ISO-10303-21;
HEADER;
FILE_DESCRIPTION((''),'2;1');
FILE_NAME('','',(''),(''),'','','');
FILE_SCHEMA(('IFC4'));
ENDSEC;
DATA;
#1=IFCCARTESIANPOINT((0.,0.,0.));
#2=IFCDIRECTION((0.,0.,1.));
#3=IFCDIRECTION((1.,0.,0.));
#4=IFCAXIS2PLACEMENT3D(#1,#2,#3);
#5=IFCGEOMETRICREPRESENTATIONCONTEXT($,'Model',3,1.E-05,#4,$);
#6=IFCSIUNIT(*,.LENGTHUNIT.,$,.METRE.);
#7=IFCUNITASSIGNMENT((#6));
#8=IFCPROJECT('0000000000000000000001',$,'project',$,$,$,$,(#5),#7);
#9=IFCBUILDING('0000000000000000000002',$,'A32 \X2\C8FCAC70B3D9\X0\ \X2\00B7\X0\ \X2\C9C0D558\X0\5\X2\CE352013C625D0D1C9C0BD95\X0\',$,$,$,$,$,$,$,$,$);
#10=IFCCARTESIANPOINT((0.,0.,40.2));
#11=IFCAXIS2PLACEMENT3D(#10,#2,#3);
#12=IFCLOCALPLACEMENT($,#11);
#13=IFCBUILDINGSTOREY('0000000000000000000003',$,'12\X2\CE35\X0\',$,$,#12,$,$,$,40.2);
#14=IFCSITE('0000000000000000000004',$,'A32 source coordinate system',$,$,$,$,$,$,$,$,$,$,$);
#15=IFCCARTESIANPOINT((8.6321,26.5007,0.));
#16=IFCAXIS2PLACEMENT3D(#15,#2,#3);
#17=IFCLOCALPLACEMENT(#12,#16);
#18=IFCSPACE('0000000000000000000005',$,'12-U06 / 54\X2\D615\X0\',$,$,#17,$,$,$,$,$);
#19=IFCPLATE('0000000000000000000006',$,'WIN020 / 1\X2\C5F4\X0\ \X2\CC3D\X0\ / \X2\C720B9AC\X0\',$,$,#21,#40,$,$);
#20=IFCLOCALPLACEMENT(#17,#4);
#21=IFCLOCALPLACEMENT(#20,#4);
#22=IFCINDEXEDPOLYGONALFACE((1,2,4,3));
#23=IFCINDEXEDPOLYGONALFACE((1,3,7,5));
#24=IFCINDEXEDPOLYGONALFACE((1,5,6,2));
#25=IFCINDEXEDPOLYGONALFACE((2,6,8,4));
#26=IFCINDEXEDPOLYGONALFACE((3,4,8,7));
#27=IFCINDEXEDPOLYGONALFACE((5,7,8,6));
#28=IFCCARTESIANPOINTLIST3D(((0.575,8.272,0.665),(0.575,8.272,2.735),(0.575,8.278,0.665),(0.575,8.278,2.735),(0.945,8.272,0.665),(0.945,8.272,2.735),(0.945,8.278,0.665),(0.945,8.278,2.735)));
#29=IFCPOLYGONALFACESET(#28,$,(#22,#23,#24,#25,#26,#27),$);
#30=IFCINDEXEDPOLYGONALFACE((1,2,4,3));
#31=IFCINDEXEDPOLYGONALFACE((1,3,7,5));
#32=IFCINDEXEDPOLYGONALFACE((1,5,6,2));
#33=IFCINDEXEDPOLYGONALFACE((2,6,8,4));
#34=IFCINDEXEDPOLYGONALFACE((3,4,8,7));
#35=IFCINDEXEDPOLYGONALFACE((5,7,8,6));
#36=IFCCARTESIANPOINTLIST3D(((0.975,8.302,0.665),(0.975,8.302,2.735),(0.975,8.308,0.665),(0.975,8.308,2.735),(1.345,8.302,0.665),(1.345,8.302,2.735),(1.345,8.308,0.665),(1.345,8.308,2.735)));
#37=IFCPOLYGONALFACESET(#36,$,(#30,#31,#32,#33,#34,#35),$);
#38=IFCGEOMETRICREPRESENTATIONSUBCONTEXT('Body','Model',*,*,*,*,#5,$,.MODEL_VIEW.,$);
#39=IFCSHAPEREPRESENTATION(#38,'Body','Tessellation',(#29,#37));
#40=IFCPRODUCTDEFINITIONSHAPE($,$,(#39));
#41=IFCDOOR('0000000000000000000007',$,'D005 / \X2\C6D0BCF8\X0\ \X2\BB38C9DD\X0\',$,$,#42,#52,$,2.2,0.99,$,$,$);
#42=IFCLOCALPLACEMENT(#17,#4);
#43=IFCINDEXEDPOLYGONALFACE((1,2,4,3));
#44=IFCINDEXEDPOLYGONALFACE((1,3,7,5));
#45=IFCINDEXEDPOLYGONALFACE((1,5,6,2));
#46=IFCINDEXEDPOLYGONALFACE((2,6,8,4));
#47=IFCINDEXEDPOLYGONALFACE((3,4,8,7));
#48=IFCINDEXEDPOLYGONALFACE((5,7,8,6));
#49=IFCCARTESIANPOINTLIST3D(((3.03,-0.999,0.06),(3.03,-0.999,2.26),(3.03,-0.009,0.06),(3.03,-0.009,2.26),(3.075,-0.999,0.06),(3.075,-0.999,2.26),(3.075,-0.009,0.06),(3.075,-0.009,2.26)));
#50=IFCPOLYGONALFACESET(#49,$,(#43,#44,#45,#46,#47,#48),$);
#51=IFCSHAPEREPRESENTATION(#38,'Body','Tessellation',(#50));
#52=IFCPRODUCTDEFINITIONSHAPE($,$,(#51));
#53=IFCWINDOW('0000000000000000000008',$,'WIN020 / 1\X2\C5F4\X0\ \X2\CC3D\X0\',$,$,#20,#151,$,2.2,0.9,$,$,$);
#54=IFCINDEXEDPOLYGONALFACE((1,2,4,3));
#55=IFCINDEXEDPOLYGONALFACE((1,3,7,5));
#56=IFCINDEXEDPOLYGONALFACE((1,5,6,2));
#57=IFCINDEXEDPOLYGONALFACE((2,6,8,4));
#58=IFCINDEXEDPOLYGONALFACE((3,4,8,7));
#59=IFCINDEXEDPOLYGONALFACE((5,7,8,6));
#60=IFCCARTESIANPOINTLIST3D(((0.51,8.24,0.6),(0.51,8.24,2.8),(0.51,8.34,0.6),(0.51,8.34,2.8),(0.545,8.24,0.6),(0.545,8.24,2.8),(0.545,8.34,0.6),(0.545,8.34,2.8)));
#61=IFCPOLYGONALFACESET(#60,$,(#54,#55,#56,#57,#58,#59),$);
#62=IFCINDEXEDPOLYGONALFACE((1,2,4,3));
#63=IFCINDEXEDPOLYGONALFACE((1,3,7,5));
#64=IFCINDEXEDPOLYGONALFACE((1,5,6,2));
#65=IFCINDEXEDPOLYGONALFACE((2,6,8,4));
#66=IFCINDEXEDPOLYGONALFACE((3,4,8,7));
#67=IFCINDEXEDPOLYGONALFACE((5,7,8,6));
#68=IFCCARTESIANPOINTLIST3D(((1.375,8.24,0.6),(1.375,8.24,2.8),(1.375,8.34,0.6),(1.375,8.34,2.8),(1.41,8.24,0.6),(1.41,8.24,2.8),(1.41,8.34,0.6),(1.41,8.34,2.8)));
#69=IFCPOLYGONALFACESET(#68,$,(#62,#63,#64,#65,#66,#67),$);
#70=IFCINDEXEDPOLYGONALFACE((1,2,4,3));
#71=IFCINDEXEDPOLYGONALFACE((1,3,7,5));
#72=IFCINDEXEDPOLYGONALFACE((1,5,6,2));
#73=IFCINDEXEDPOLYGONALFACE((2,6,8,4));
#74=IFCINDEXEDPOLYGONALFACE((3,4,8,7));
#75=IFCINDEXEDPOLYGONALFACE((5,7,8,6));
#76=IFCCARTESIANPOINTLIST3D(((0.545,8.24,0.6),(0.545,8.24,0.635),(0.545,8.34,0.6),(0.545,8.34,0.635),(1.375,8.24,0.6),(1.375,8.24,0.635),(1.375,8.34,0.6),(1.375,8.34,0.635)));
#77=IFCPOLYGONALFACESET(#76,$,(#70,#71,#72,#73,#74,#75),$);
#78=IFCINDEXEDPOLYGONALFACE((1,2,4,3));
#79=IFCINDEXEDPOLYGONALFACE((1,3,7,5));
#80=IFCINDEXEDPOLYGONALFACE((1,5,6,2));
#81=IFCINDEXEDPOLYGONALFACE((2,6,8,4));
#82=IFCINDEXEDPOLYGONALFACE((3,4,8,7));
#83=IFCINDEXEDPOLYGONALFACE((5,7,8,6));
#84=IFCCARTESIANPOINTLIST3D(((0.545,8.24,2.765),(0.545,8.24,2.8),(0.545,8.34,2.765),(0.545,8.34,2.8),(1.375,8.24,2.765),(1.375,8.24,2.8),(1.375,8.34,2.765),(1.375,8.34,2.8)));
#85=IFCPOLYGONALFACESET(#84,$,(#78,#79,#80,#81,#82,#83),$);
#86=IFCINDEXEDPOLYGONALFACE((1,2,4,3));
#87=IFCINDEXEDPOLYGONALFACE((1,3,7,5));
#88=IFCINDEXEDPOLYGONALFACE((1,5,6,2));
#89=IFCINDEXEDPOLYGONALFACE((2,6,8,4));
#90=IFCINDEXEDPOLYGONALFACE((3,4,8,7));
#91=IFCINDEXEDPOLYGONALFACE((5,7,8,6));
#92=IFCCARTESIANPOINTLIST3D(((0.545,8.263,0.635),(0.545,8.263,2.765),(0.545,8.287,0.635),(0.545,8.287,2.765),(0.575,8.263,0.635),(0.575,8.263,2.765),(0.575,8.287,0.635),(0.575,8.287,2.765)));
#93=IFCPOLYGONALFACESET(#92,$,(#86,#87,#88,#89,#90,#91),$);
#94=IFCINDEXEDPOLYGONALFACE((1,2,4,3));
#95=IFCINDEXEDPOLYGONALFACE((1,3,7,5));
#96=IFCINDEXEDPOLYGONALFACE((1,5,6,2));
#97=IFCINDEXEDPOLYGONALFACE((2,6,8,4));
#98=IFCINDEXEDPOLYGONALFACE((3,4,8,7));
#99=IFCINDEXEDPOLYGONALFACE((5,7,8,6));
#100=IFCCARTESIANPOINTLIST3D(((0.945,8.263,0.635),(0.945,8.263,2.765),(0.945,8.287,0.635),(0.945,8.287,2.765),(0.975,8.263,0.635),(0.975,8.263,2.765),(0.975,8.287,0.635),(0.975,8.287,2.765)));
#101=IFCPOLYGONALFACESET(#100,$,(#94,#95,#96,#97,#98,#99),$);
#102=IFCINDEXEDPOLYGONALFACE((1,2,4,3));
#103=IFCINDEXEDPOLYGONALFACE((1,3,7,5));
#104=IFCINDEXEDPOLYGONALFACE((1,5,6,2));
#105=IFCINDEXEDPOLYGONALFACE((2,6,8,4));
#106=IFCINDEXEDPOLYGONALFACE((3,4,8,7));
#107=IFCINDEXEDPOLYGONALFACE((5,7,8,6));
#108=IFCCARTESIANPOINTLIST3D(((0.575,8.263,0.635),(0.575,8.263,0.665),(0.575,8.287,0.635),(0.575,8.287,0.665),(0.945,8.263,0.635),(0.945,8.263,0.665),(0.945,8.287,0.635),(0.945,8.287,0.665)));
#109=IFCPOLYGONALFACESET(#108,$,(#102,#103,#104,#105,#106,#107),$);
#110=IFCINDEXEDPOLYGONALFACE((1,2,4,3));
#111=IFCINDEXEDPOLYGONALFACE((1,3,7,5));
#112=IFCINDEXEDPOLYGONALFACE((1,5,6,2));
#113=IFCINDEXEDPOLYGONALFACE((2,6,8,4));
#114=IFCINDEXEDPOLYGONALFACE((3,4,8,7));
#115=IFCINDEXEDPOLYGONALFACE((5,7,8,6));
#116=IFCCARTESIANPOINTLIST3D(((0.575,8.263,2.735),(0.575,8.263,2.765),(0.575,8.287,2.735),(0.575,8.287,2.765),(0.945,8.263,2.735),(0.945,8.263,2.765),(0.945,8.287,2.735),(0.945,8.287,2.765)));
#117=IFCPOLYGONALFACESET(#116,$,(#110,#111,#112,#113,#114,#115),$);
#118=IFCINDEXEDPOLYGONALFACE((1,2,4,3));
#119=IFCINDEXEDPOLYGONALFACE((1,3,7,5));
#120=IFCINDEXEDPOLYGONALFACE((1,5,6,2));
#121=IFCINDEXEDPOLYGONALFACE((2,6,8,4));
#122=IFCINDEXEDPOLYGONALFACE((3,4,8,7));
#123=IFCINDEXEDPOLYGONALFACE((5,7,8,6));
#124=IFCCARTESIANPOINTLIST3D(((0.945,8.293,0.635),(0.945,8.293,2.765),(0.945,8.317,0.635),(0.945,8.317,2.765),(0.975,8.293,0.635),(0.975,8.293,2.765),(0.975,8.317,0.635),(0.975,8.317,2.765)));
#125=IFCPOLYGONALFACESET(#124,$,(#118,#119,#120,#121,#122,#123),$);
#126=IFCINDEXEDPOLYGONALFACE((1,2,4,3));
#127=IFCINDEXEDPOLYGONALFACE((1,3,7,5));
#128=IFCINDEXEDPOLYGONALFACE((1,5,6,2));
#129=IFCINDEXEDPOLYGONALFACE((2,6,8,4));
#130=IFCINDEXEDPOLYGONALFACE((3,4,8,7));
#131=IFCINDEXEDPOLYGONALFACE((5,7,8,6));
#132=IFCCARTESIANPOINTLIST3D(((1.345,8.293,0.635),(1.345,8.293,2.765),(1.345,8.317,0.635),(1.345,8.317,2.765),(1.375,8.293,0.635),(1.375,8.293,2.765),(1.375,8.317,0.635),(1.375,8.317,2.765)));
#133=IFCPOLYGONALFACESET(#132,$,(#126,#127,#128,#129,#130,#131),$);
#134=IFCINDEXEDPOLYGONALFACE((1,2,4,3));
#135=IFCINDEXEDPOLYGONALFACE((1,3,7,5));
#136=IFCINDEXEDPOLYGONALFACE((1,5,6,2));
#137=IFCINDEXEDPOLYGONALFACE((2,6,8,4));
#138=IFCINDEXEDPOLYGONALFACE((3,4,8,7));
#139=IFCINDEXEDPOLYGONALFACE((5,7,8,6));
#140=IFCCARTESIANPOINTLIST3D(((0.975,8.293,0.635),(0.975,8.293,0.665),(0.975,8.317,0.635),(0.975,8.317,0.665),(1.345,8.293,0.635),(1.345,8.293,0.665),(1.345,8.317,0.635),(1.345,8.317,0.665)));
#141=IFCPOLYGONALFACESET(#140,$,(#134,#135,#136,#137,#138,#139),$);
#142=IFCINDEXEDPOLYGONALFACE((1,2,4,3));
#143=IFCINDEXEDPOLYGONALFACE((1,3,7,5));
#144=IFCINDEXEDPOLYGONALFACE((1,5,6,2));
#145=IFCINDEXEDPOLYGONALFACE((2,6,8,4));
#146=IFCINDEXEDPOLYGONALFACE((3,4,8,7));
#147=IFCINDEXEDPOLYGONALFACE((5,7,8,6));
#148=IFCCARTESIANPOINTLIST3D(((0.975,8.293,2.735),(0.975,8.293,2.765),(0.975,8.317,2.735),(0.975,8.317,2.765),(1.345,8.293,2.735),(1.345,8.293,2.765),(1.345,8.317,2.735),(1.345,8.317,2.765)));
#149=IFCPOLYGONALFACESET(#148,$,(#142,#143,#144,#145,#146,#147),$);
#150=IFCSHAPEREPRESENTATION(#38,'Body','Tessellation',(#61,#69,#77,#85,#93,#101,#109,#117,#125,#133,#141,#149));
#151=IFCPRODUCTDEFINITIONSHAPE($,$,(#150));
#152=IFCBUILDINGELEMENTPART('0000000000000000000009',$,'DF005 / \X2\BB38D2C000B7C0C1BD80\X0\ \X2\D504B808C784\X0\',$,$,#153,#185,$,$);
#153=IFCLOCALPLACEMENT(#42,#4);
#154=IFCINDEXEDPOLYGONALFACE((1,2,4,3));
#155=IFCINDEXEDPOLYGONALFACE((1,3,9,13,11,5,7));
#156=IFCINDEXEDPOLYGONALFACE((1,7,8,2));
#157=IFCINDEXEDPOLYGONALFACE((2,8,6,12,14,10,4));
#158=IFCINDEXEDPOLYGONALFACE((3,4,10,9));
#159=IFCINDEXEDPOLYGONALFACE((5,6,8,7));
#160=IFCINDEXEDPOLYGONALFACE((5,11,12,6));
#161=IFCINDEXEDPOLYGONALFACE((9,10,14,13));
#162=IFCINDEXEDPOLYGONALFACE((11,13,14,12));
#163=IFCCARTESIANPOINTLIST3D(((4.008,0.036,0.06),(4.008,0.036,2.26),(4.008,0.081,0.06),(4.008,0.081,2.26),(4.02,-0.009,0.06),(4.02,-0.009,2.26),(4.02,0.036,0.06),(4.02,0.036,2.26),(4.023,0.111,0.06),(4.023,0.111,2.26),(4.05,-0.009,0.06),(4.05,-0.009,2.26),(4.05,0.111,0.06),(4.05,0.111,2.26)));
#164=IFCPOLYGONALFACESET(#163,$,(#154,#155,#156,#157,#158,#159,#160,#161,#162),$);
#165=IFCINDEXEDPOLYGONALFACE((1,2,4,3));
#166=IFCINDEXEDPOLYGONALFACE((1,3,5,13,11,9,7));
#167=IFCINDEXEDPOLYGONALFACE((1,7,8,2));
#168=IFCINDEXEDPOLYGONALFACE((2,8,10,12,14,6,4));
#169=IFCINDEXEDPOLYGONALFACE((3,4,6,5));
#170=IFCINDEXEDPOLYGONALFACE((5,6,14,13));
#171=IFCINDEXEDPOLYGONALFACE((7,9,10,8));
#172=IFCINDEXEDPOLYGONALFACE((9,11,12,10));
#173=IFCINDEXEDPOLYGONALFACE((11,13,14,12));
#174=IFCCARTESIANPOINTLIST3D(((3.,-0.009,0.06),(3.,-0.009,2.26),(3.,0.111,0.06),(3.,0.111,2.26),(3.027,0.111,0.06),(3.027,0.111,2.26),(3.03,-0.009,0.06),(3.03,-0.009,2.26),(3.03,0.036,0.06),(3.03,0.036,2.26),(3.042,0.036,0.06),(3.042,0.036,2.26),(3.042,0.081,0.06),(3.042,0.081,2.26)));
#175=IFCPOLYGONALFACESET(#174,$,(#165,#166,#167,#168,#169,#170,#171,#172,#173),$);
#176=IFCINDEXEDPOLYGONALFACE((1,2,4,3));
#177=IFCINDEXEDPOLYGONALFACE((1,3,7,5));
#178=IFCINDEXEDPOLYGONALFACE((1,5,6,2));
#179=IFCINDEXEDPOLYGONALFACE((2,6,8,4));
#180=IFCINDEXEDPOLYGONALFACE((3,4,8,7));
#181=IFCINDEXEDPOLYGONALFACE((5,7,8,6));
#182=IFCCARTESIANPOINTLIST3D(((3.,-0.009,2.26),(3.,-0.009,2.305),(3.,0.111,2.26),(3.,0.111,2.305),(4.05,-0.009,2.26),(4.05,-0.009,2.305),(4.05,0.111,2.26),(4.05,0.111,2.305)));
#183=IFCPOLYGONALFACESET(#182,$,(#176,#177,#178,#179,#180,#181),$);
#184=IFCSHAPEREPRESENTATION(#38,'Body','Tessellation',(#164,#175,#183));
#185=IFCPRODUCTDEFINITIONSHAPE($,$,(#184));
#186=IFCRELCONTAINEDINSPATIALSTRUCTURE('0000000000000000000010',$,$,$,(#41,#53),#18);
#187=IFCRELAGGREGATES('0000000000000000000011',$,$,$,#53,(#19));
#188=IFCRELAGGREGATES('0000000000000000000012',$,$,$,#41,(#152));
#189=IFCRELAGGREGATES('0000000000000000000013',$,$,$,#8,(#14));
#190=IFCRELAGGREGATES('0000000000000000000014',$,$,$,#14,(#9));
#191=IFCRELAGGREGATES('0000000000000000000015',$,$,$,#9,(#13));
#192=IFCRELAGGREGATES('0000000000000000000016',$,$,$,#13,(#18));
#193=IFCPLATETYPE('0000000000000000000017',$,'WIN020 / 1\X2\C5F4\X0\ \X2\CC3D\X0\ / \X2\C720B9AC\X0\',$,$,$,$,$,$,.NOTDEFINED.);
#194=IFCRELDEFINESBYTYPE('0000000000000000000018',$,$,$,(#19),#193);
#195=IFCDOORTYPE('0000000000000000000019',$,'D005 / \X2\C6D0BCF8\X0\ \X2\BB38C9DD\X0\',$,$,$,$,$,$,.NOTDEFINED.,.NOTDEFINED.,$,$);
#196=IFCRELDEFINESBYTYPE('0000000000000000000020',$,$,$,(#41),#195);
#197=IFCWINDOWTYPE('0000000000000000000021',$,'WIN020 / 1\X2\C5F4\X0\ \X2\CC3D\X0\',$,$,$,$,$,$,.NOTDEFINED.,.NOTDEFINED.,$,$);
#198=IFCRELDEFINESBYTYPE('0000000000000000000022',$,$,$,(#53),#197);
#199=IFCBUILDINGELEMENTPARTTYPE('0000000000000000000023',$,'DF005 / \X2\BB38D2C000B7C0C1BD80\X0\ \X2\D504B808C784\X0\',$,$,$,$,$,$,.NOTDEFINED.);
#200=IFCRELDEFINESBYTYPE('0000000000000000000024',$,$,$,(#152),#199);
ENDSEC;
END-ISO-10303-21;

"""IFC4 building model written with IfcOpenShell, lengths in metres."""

from ifc_helpers import new_model, si_unit, frame, origin, origin_with_axes, place, context, subcontext, project, spatial, polyline, outline, extrude, source, transform, mapped, type_object, type_shapes, element, aggregate, save


model = new_model("IFC4")

# Units and contexts
model_context = context("Model", 3, precision=1e-05, world=origin_with_axes())
body_context = subcontext(model_context, "Body", "Model", "MODEL_VIEW")
ifc_project = project(units=[si_unit("LENGTHUNIT", "METRE")], contexts=[model_context])

# Plate
storey_placement = place(None, frame((0.0, 0.0, 40.2), z_axis=(0.0, 0.0, 1.0), x_axis=(1.0, 0.0, 0.0)))
space_1_placement = place(storey_placement, frame((8.6321, 26.5007, 0.0), z_axis=(0.0, 0.0, 1.0), x_axis=(1.0, 0.0, 0.0)))
plate_type_1 = type_object("IfcPlateType", Name="WIN020 / 1열 창 / 유리", PredefinedType="NOTDEFINED")
shared_shape_1 = source(origin(), body_context, "Body", "SweptSolid", [
    extrude(outline(polyline([(0.575, 8.272), (0.575, 8.278), (0.945, 8.278), (0.945, 8.272), (0.575, 8.272)])), frame((0.0, 0.0, 0.665)), (0.0, 0.0, 1.0), 2.07),
    extrude(outline(polyline([(0.975, 8.302), (0.975, 8.308), (1.345, 8.308), (1.345, 8.302), (0.975, 8.302)])), frame((0.0, 0.0, 0.665)), (0.0, 0.0, 1.0), 2.07),
])
type_shapes(plate_type_1, [shared_shape_1])
window_1_placement = place(space_1_placement, origin_with_axes())
plate_1_placement = place(window_1_placement, origin_with_axes())
plate_1 = element("IfcPlate", 1, at=plate_1_placement, type_object=plate_type_1, Name="WIN020 / 1열 창 / 유리", context=body_context, shape_type="MappedRepresentation", body=[
    mapped(shared_shape_1, transform((0.0, 0.0, 0.0), scale=1.0)),
])

# Site, building, storey, space
site = spatial("IfcSite", under=ifc_project, Name="A32 source coordinate system")
building = spatial("IfcBuilding", under=site, Name="A32 주거동 · 지하5층–옥탑지붕")
storey = spatial("IfcBuildingStorey", under=building, at=storey_placement, Name="12층", Elevation=40.2)
space_1 = spatial("IfcSpace", under=storey, at=space_1_placement, Name="12-U06 / 54형")

# Door
door_type_1 = type_object("IfcDoorType", Name="D005 / 원본 문짝", OperationType="NOTDEFINED", PredefinedType="NOTDEFINED")
shared_shape_2 = source(origin(), body_context, "Body", "SweptSolid", [
    extrude(outline(polyline([(3.075, -0.999), (3.03, -0.999), (3.03, -0.009), (3.075, -0.009), (3.075, -0.999)])), frame((0.0, 0.0, 0.06)), (0.0, 0.0, 1.0), 2.2),
])
type_shapes(door_type_1, [shared_shape_2])
door_1_placement = place(space_1_placement, origin_with_axes())
door_1 = element("IfcDoor", 2, at=door_1_placement, inside=space_1, type_object=door_type_1, Name="D005 / 원본 문짝", OverallHeight=2.2, OverallWidth=0.99, context=body_context, shape_type="MappedRepresentation", body=[
    mapped(shared_shape_2, transform((0.0, 0.0, 0.0), scale=1.0)),
])

# Window
window_type_1 = type_object("IfcWindowType", Name="WIN020 / 1열 창", PartitioningType="NOTDEFINED", PredefinedType="NOTDEFINED")
shared_shape_3 = source(origin(), body_context, "Body", "SweptSolid", [
    extrude(outline(polyline([(0.51, 8.24), (0.51, 8.34), (0.545, 8.34), (0.545, 8.24), (0.51, 8.24)])), frame((0.0, 0.0, 0.6)), (0.0, 0.0, 1.0), 2.2),
    extrude(outline(polyline([(1.375, 8.24), (1.375, 8.34), (1.41, 8.34), (1.41, 8.24), (1.375, 8.24)])), frame((0.0, 0.0, 0.6)), (0.0, 0.0, 1.0), 2.2),
    extrude(outline(polyline([(0.545, 8.24), (0.545, 8.34), (1.375, 8.34), (1.375, 8.24), (0.545, 8.24)])), frame((0.0, 0.0, 0.6)), (0.0, 0.0, 1.0), 0.035),
    extrude(outline(polyline([(0.545, 8.24), (0.545, 8.34), (1.375, 8.34), (1.375, 8.24), (0.545, 8.24)])), frame((0.0, 0.0, 2.765)), (0.0, 0.0, 1.0), 0.035),
    extrude(outline(polyline([(0.545, 8.263), (0.545, 8.287), (0.575, 8.287), (0.575, 8.263), (0.545, 8.263)])), frame((0.0, 0.0, 0.635)), (0.0, 0.0, 1.0), 2.13),
    extrude(outline(polyline([(0.945, 8.263), (0.945, 8.287), (0.975, 8.287), (0.975, 8.263), (0.945, 8.263)])), frame((0.0, 0.0, 0.635)), (0.0, 0.0, 1.0), 2.13),
    extrude(outline(polyline([(0.575, 8.263), (0.575, 8.287), (0.945, 8.287), (0.945, 8.263), (0.575, 8.263)])), frame((0.0, 0.0, 0.635)), (0.0, 0.0, 1.0), 0.03),
    extrude(outline(polyline([(0.575, 8.263), (0.575, 8.287), (0.945, 8.287), (0.945, 8.263), (0.575, 8.263)])), frame((0.0, 0.0, 2.735)), (0.0, 0.0, 1.0), 0.03),
    extrude(outline(polyline([(0.945, 8.293), (0.945, 8.317), (0.975, 8.317), (0.975, 8.293), (0.945, 8.293)])), frame((0.0, 0.0, 0.635)), (0.0, 0.0, 1.0), 2.13),
    extrude(outline(polyline([(1.345, 8.293), (1.345, 8.317), (1.375, 8.317), (1.375, 8.293), (1.345, 8.293)])), frame((0.0, 0.0, 0.635)), (0.0, 0.0, 1.0), 2.13),
    extrude(outline(polyline([(0.975, 8.293), (0.975, 8.317), (1.345, 8.317), (1.345, 8.293), (0.975, 8.293)])), frame((0.0, 0.0, 0.635)), (0.0, 0.0, 1.0), 0.03),
    extrude(outline(polyline([(0.975, 8.293), (0.975, 8.317), (1.345, 8.317), (1.345, 8.293), (0.975, 8.293)])), frame((0.0, 0.0, 2.735)), (0.0, 0.0, 1.0), 0.03),
])
type_shapes(window_type_1, [shared_shape_3])
window_1 = element("IfcWindow", 3, at=window_1_placement, inside=space_1, type_object=window_type_1, Name="WIN020 / 1열 창", OverallHeight=2.2, OverallWidth=0.9, context=body_context, shape_type="MappedRepresentation", body=[
    mapped(shared_shape_3, transform((0.0, 0.0, 0.0), scale=1.0)),
])
aggregate(window_1, [plate_1])

# Building element part
building_element_part_type_1 = type_object("IfcBuildingElementPartType", Name="DF005 / 문틀·상부 프레임", PredefinedType="NOTDEFINED")
shared_shape_4 = source(origin(), body_context, "Body", "SweptSolid", [
    extrude(outline(polyline([(4.02, -0.009), (4.02, 0.036), (4.008, 0.036), (4.008, 0.081), (4.023, 0.111), (4.05, 0.111), (4.05, -0.009), (4.02, -0.009)])), frame((0.0, 0.0, 0.06)), (0.0, 0.0, 1.0), 2.2),
    extrude(outline(polyline([(3.0, 0.111), (3.027, 0.111), (3.042, 0.081), (3.042, 0.036), (3.03, 0.036), (3.03, -0.009), (3.0, -0.009), (3.0, 0.111)])), frame((0.0, 0.0, 0.06)), (0.0, 0.0, 1.0), 2.2),
    extrude(outline(polyline([(3.0, -0.009), (3.0, 0.111), (4.05, 0.111), (4.05, -0.009), (3.0, -0.009)])), frame((0.0, 0.0, 2.26)), (0.0, 0.0, 1.0), 0.045),
])
type_shapes(building_element_part_type_1, [shared_shape_4])
building_element_part_1_placement = place(door_1_placement, origin_with_axes())
building_element_part_1 = element("IfcBuildingElementPart", 4, at=building_element_part_1_placement, type_object=building_element_part_type_1, Name="DF005 / 문틀·상부 프레임", context=body_context, shape_type="MappedRepresentation", body=[
    mapped(shared_shape_4, transform((0.0, 0.0, 0.0), scale=1.0)),
])
aggregate(door_1, [building_element_part_1])

save(model, "model.ifc")
